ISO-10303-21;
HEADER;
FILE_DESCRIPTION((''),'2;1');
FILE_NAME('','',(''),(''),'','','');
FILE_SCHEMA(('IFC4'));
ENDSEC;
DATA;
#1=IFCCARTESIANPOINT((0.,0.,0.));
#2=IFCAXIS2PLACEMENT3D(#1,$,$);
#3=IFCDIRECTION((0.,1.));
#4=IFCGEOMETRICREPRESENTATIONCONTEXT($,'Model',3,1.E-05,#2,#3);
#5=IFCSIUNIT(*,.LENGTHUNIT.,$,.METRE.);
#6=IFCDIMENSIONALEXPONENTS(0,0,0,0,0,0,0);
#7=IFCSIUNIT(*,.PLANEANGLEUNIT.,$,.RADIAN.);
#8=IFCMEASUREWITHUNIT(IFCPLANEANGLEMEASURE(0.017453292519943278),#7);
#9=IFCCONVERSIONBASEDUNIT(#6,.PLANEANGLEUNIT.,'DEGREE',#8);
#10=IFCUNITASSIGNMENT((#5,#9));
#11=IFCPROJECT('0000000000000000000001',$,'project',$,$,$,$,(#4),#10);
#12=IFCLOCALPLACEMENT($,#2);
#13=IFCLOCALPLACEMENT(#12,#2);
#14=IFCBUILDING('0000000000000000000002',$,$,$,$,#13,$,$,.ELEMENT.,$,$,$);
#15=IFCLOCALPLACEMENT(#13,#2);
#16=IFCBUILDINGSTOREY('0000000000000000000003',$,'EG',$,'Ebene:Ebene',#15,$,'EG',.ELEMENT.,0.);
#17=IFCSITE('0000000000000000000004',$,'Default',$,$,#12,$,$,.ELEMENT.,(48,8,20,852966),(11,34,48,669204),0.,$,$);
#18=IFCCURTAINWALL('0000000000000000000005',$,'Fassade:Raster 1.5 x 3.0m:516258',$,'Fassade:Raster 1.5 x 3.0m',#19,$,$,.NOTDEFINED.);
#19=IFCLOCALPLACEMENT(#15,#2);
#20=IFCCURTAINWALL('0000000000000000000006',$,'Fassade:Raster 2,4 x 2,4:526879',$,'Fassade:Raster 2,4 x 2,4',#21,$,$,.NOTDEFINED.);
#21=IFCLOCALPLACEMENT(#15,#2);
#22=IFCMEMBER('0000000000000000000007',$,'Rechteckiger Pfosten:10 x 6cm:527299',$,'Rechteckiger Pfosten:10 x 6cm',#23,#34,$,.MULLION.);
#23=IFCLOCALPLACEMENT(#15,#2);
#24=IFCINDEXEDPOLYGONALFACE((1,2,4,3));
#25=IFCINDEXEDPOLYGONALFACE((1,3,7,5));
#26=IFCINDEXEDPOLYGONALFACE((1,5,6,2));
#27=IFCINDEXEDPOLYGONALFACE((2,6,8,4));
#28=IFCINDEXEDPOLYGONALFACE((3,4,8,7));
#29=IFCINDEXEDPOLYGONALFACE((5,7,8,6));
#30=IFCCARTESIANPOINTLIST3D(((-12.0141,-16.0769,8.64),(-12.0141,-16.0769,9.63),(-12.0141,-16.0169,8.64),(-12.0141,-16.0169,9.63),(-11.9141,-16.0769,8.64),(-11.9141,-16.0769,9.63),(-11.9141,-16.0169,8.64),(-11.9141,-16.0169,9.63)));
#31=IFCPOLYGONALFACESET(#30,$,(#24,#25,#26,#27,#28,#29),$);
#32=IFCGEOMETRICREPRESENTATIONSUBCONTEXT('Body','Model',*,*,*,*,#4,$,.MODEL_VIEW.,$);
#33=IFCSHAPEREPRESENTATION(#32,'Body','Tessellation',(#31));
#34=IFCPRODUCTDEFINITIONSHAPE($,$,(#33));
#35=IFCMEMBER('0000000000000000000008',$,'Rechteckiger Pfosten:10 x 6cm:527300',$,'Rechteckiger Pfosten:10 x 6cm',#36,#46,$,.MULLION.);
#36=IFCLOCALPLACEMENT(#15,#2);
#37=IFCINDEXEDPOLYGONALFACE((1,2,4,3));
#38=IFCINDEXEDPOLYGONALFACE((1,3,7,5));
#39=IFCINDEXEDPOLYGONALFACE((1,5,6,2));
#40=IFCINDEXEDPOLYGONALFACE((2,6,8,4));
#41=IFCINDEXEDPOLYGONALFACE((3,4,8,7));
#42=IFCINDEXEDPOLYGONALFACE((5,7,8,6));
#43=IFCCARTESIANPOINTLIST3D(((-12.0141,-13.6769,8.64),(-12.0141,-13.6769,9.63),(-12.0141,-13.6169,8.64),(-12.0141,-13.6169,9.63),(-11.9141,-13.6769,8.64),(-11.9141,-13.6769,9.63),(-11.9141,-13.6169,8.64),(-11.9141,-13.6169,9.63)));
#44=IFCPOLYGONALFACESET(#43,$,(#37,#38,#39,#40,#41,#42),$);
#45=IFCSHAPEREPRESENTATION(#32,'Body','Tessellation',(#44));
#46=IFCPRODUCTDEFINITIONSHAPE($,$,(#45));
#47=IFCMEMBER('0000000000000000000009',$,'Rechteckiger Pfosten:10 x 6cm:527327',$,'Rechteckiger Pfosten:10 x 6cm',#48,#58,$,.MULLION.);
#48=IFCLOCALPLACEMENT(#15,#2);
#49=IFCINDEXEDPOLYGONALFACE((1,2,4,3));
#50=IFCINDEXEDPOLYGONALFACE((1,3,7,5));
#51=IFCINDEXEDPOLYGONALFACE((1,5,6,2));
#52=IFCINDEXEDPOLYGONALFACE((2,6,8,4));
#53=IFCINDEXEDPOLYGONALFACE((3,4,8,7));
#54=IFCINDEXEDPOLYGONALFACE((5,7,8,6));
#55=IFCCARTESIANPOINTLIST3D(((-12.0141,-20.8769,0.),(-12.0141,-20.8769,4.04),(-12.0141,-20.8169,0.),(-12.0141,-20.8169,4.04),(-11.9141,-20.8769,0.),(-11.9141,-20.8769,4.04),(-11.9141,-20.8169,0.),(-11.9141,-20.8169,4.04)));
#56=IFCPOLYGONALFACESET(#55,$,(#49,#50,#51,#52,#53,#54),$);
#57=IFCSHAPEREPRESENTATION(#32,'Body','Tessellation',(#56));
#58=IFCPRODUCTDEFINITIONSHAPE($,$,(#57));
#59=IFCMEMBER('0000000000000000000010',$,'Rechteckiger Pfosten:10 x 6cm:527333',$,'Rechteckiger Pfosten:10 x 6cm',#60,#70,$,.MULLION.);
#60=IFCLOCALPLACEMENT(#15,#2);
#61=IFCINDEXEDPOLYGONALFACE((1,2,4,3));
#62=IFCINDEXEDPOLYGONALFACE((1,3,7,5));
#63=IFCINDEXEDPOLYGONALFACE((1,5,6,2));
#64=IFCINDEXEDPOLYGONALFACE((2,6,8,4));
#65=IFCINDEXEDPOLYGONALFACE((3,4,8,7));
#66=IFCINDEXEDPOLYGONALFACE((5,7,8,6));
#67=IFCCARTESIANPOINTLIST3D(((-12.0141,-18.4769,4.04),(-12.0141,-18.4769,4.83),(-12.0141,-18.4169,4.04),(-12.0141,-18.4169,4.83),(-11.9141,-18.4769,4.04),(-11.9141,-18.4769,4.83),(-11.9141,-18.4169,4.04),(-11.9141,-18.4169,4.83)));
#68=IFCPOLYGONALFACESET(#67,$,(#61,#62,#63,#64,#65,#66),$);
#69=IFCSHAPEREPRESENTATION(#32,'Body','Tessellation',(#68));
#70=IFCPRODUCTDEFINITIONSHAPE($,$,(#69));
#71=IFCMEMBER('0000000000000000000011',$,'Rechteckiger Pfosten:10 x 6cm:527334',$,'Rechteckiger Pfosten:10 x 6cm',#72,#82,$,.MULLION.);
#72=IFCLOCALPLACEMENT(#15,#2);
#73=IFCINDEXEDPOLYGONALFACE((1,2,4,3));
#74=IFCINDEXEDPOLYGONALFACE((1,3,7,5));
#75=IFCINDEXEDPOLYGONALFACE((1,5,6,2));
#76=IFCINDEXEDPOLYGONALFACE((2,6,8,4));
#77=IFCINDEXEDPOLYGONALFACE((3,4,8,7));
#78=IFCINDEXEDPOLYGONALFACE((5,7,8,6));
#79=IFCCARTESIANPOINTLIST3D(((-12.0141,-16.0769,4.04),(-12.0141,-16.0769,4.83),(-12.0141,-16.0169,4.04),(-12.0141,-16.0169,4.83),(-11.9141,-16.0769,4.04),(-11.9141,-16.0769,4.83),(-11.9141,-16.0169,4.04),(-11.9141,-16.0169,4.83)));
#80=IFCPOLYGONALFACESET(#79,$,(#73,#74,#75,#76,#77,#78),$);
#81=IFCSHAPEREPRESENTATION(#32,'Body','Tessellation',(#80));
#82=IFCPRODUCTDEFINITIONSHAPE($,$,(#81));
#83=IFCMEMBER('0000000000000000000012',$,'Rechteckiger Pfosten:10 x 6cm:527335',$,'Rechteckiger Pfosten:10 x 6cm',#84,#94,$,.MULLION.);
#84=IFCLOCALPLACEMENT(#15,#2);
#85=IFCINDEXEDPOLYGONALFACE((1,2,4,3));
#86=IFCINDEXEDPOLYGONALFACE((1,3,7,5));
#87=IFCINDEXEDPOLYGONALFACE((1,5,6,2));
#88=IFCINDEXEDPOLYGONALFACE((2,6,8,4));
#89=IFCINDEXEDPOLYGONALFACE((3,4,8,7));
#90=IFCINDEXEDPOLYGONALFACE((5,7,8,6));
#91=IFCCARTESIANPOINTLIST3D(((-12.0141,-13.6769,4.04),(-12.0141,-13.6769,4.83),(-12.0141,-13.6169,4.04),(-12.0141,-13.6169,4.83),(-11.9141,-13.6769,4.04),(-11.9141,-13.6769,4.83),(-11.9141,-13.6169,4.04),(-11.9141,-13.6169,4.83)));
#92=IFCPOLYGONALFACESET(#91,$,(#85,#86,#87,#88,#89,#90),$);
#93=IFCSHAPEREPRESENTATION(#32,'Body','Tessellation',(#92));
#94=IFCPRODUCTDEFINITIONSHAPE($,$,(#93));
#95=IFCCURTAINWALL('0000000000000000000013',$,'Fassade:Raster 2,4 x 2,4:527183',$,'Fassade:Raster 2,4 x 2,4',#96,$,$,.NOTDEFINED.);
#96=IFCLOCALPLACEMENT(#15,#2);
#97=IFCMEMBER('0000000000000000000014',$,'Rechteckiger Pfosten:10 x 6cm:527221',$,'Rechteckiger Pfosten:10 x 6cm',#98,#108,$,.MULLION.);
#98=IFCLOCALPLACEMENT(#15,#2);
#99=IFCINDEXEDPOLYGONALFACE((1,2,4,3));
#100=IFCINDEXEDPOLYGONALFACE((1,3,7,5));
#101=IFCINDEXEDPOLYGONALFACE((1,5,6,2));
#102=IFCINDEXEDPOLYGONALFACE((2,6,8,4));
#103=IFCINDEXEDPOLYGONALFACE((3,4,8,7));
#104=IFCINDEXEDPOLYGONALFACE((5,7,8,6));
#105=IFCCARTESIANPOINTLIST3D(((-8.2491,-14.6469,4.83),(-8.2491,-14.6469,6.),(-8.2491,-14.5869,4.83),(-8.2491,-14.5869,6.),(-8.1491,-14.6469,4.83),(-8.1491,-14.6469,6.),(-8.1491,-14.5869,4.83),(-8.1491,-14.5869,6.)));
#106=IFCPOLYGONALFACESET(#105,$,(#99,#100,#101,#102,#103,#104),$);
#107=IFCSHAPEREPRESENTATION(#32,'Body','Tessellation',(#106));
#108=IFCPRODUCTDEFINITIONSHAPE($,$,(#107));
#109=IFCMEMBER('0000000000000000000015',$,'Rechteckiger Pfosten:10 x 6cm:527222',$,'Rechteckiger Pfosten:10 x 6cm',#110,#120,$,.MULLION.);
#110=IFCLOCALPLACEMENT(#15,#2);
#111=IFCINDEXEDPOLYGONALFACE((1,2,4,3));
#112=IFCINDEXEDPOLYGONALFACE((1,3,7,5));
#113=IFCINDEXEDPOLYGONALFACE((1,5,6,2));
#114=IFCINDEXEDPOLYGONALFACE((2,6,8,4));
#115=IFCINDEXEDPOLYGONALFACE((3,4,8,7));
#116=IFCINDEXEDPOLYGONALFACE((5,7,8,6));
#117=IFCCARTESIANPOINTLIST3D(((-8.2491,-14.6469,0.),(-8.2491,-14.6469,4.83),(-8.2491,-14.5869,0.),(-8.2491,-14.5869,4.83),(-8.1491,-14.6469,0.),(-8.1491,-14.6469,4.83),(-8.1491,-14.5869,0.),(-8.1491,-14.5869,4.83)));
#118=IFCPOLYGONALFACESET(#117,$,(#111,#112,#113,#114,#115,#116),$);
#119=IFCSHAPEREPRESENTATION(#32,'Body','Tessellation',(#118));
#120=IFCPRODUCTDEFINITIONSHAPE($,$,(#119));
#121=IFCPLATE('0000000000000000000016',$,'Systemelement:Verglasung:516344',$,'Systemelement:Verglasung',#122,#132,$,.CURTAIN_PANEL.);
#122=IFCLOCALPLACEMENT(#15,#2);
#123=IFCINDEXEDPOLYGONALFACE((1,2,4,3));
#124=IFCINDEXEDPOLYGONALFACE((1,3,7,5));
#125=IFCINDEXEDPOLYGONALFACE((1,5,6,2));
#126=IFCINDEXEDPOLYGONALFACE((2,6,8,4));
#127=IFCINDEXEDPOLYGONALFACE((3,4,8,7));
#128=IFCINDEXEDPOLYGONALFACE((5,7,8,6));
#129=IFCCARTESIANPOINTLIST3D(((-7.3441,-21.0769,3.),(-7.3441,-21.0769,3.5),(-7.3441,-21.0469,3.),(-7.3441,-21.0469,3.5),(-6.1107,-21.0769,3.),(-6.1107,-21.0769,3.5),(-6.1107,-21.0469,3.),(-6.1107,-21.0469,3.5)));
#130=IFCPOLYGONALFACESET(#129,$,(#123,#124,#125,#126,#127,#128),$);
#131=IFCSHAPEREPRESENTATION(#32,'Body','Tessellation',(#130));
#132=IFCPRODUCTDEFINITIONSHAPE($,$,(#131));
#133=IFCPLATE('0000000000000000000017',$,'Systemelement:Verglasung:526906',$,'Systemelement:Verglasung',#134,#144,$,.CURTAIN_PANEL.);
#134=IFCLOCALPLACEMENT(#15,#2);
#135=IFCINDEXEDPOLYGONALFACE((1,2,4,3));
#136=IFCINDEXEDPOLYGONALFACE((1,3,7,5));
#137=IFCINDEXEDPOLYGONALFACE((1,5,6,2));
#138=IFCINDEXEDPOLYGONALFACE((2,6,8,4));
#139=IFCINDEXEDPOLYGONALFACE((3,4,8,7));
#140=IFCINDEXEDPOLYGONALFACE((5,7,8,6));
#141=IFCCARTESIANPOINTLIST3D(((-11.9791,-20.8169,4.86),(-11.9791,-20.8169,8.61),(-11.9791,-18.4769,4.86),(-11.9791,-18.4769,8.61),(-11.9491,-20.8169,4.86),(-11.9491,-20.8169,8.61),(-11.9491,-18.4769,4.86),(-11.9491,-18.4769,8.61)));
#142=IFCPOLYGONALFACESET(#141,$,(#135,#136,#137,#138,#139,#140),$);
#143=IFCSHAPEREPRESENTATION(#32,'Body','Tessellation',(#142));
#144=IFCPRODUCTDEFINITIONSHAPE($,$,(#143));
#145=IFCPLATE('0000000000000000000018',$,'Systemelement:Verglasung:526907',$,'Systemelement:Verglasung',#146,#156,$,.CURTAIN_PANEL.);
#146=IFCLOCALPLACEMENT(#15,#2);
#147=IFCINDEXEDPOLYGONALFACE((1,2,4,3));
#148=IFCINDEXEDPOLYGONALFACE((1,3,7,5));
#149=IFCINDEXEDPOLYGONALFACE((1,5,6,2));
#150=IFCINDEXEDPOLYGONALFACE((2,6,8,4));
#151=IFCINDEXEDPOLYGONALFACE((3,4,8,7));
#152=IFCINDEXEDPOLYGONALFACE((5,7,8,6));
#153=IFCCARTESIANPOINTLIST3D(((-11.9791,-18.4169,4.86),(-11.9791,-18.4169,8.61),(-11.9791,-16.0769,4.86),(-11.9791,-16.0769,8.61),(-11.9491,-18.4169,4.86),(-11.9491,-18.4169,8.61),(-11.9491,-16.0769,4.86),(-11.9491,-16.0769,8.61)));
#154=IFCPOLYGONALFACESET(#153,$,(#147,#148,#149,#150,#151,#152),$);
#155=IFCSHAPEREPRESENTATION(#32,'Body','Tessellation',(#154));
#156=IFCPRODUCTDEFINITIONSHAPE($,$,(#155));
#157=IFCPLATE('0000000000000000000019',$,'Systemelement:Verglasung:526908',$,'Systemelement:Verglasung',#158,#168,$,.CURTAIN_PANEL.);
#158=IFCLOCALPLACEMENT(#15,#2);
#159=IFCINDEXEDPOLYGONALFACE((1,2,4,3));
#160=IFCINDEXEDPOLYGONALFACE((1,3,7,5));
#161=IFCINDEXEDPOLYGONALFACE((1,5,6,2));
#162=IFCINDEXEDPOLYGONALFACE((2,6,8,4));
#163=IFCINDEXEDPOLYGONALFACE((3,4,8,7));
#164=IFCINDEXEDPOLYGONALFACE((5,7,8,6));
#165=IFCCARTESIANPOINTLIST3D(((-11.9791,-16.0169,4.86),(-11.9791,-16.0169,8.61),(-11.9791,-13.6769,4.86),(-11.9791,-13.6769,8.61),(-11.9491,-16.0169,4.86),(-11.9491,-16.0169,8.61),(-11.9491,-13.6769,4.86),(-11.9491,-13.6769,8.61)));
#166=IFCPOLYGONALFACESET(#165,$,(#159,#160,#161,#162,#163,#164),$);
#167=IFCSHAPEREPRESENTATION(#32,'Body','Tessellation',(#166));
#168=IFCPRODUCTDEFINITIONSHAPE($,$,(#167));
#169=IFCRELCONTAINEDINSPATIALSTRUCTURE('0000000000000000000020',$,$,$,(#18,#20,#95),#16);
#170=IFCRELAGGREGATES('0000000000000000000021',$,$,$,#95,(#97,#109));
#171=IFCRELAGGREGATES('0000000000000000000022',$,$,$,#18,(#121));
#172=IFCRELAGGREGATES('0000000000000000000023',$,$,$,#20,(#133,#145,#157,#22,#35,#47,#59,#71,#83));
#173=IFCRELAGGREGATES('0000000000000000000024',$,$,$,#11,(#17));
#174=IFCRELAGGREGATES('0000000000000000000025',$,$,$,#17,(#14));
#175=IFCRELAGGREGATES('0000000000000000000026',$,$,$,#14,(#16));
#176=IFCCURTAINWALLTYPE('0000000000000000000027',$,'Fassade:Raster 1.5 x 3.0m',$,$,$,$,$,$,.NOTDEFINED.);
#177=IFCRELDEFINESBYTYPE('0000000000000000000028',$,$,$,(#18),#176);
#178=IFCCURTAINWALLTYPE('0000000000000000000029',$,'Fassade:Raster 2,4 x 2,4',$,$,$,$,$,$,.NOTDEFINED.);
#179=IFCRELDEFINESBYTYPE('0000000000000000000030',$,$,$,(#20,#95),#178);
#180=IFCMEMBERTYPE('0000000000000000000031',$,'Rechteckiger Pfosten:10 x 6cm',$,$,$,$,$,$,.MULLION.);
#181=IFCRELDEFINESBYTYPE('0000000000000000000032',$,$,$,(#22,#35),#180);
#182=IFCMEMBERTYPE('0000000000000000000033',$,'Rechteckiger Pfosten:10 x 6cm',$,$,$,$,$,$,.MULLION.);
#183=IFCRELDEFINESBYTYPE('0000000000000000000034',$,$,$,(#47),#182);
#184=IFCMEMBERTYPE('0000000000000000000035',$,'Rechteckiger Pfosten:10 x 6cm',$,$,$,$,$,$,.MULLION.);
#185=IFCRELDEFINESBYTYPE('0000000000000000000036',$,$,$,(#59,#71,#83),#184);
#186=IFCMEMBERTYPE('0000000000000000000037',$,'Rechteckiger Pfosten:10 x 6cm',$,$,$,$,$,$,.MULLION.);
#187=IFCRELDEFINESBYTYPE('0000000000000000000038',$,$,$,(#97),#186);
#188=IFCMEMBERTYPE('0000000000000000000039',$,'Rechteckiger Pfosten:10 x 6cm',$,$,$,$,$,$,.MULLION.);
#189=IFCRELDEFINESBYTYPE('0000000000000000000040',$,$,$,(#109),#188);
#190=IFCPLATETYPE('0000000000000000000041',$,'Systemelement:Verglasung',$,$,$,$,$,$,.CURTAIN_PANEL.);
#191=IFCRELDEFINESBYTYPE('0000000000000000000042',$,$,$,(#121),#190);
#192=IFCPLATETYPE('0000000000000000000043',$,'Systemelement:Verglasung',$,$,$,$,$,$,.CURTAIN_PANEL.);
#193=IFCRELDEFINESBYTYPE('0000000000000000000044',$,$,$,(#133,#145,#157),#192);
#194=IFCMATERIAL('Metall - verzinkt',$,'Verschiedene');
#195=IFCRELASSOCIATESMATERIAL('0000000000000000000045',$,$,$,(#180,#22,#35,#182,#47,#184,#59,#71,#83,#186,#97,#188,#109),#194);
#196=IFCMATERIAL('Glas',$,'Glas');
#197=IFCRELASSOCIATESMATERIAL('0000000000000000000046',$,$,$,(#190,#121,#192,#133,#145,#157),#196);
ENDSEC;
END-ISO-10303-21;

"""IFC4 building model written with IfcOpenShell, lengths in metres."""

from ifc_helpers import new_model, entity, si_unit, converted_unit, direction, frame, origin, place, context, subcontext, project, spatial, indexed_curve, outline, extrude, source, transform, mapped, material, type_object, type_shapes, element, aggregate, save


model = new_model("IFC4")

# Units and contexts
model_context = context("Model", 3, precision=1e-05, world=origin(), true_north=direction((0.0, 1.0)))
body_context = subcontext(model_context, "Body", "Model", "MODEL_VIEW")
ifc_project = project(units=[si_unit("LENGTHUNIT", "METRE"), converted_unit("PLANEANGLEUNIT", "DEGREE", entity("IfcPlaneAngleMeasure", 0.017453292519943278), si_unit("PLANEANGLEUNIT", "RADIAN"), dimensions=[0, 0, 0, 0, 0, 0, 0])], contexts=[model_context])

# Site, building, storey
site_placement = place(None, origin())
site = spatial("IfcSite", under=ifc_project, at=site_placement, Name="Default", CompositionType="ELEMENT", RefLatitude=(48, 8, 20, 852966), RefLongitude=(11, 34, 48, 669204), RefElevation=0.0)
building_placement = place(site_placement, origin())
building = spatial("IfcBuilding", under=site, at=building_placement, CompositionType="ELEMENT")
storey_placement = place(building_placement, origin())
storey = spatial("IfcBuildingStorey", under=building, at=storey_placement, Name="EG", ObjectType="Ebene:Ebene", LongName="EG", CompositionType="ELEMENT", Elevation=0.0)

# Curtain wall
curtain_wall_type_1 = type_object("IfcCurtainWallType", Name="Fassade:Raster 1.5 x 3.0m", PredefinedType="NOTDEFINED")
curtain_wall_1_placement = place(storey_placement, origin())
curtain_wall_1 = element("IfcCurtainWall", 1, at=curtain_wall_1_placement, inside=storey, type_object=curtain_wall_type_1, Name="Fassade:Raster 1.5 x 3.0m:516258", ObjectType="Fassade:Raster 1.5 x 3.0m", PredefinedType="NOTDEFINED")
ifc_material_1 = material(Name="Metall - verzinkt", Category="Verschiedene")

# Curtain walls, members
curtain_wall_type_2 = type_object("IfcCurtainWallType", Name="Fassade:Raster 2,4 x 2,4", PredefinedType="NOTDEFINED")
curtain_wall_2_placement = place(storey_placement, origin())
curtain_wall_2 = element("IfcCurtainWall", 2, at=curtain_wall_2_placement, inside=storey, type_object=curtain_wall_type_2, Name="Fassade:Raster 2,4 x 2,4:526879", ObjectType="Fassade:Raster 2,4 x 2,4", PredefinedType="NOTDEFINED")
member_type_1 = type_object("IfcMemberType", Name="Rechteckiger Pfosten:10 x 6cm", PredefinedType="MULLION", material=ifc_material_1)
shared_shape_1 = source(origin(), body_context, "Body", "SweptSolid", [
    extrude(outline(indexed_curve([(-0.03, -0.05), (0.03, -0.05), (0.03, 0.05), (-0.03, 0.05), (-0.03, -0.05)], self_intersect=False)), frame((0.0, 0.0, -0.99), z_axis=(0.0, 0.0, 1.0), x_axis=(-1.0, 0.0, 0.0)), (0.0, 0.0, 1.0), 0.99),
])
type_shapes(member_type_1, [shared_shape_1])
member_1_placement = place(curtain_wall_2_placement, frame((-11.9641, -16.0469, 8.64), z_axis=(0.0, 0.0, -1.0), x_axis=(0.0, 1.0, 0.0)))
member_1 = element("IfcMember", 3, at=member_1_placement, type_object=member_type_1, material=ifc_material_1, Name="Rechteckiger Pfosten:10 x 6cm:527299", ObjectType="Rechteckiger Pfosten:10 x 6cm", PredefinedType="MULLION", context=body_context, shape_type="MappedRepresentation", body=[
    mapped(shared_shape_1, transform((0.0, 0.0, 0.0), scale=1.0)),
])
member_2_placement = place(curtain_wall_2_placement, frame((-11.9641, -13.6469, 8.64), z_axis=(0.0, 0.0, -1.0), x_axis=(0.0, 1.0, 0.0)))
member_2 = element("IfcMember", 4, at=member_2_placement, type_object=member_type_1, material=ifc_material_1, Name="Rechteckiger Pfosten:10 x 6cm:527300", ObjectType="Rechteckiger Pfosten:10 x 6cm", PredefinedType="MULLION", context=body_context, shape_type="MappedRepresentation", body=[
    mapped(shared_shape_1, transform((0.0, 0.0, 0.0), scale=1.0)),
])
member_type_2 = type_object("IfcMemberType", Name="Rechteckiger Pfosten:10 x 6cm", PredefinedType="MULLION", material=ifc_material_1)
shared_shape_2 = source(origin(), body_context, "Body", "SweptSolid", [
    extrude(outline(indexed_curve([(-0.03, -0.05), (0.03, -0.05), (0.03, 0.05), (-0.03, 0.05), (-0.03, -0.05)], self_intersect=False)), frame((-0.03, 0.0, -4.04), z_axis=(0.0, 0.0, 1.0), x_axis=(-1.0, 0.0, 0.0)), (0.0, 0.0, 1.0), 4.04),
])
type_shapes(member_type_2, [shared_shape_2])
member_3_placement = place(curtain_wall_2_placement, frame((-11.9641, -20.8769, 4.04), z_axis=(0.0, 0.0, 1.0), x_axis=(0.0, -1.0, 0.0)))
member_3 = element("IfcMember", 5, at=member_3_placement, type_object=member_type_2, material=ifc_material_1, Name="Rechteckiger Pfosten:10 x 6cm:527327", ObjectType="Rechteckiger Pfosten:10 x 6cm", PredefinedType="MULLION", context=body_context, shape_type="MappedRepresentation", body=[
    mapped(shared_shape_2, transform((0.0, 0.0, 0.0), scale=1.0)),
])
member_type_3 = type_object("IfcMemberType", Name="Rechteckiger Pfosten:10 x 6cm", PredefinedType="MULLION", material=ifc_material_1)
shared_shape_3 = source(origin(), body_context, "Body", "SweptSolid", [
    extrude(outline(indexed_curve([(-0.03, -0.05), (0.03, -0.05), (0.03, 0.05), (-0.03, 0.05), (-0.03, -0.05)], self_intersect=False)), frame((0.0, 0.0, -0.79), z_axis=(0.0, 0.0, 1.0), x_axis=(-1.0, 0.0, 0.0)), (0.0, 0.0, 1.0), 0.79),
])
type_shapes(member_type_3, [shared_shape_3])
member_4_placement = place(curtain_wall_2_placement, frame((-11.9641, -18.4469, 4.04), z_axis=(0.0, 0.0, -1.0), x_axis=(0.0, 1.0, 0.0)))
member_4 = element("IfcMember", 6, at=member_4_placement, type_object=member_type_3, material=ifc_material_1, Name="Rechteckiger Pfosten:10 x 6cm:527333", ObjectType="Rechteckiger Pfosten:10 x 6cm", PredefinedType="MULLION", context=body_context, shape_type="MappedRepresentation", body=[
    mapped(shared_shape_3, transform((0.0, 0.0, 0.0), scale=1.0)),
])
member_5_placement = place(curtain_wall_2_placement, frame((-11.9641, -16.0469, 4.04), z_axis=(0.0, 0.0, -1.0), x_axis=(0.0, 1.0, 0.0)))
member_5 = element("IfcMember", 7, at=member_5_placement, type_object=member_type_3, material=ifc_material_1, Name="Rechteckiger Pfosten:10 x 6cm:527334", ObjectType="Rechteckiger Pfosten:10 x 6cm", PredefinedType="MULLION", context=body_context, shape_type="MappedRepresentation", body=[
    mapped(shared_shape_3, transform((0.0, 0.0, 0.0), scale=1.0)),
])
member_6_placement = place(curtain_wall_2_placement, frame((-11.9641, -13.6469, 4.04), z_axis=(0.0, 0.0, -1.0), x_axis=(0.0, 1.0, 0.0)))
member_6 = element("IfcMember", 8, at=member_6_placement, type_object=member_type_3, material=ifc_material_1, Name="Rechteckiger Pfosten:10 x 6cm:527335", ObjectType="Rechteckiger Pfosten:10 x 6cm", PredefinedType="MULLION", context=body_context, shape_type="MappedRepresentation", body=[
    mapped(shared_shape_3, transform((0.0, 0.0, 0.0), scale=1.0)),
])
curtain_wall_3_placement = place(storey_placement, origin())
curtain_wall_3 = element("IfcCurtainWall", 9, at=curtain_wall_3_placement, inside=storey, type_object=curtain_wall_type_2, Name="Fassade:Raster 2,4 x 2,4:527183", ObjectType="Fassade:Raster 2,4 x 2,4", PredefinedType="NOTDEFINED")
member_type_4 = type_object("IfcMemberType", Name="Rechteckiger Pfosten:10 x 6cm", PredefinedType="MULLION", material=ifc_material_1)
shared_shape_4 = source(origin(), body_context, "Body", "SweptSolid", [
    extrude(outline(indexed_curve([(-0.03, -0.05), (0.03, -0.05), (0.03, 0.05), (-0.03, 0.05), (-0.03, -0.05)], self_intersect=False)), frame((-0.03, 0.0, -1.17), z_axis=(0.0, 0.0, 1.0), x_axis=(-1.0, 0.0, 0.0)), (0.0, 0.0, 1.0), 1.17),
])
type_shapes(member_type_4, [shared_shape_4])
member_7_placement = place(curtain_wall_3_placement, frame((-8.1991, -14.6469, 6.0), z_axis=(0.0, 0.0, 1.0), x_axis=(0.0, -1.0, 0.0)))
member_7 = element("IfcMember", 10, at=member_7_placement, type_object=member_type_4, material=ifc_material_1, Name="Rechteckiger Pfosten:10 x 6cm:527221", ObjectType="Rechteckiger Pfosten:10 x 6cm", PredefinedType="MULLION", context=body_context, shape_type="MappedRepresentation", body=[
    mapped(shared_shape_4, transform((0.0, 0.0, 0.0), scale=1.0)),
])
member_type_5 = type_object("IfcMemberType", Name="Rechteckiger Pfosten:10 x 6cm", PredefinedType="MULLION", material=ifc_material_1)
shared_shape_5 = source(origin(), body_context, "Body", "SweptSolid", [
    extrude(outline(indexed_curve([(-0.03, -0.05), (0.03, -0.05), (0.03, 0.05), (-0.03, 0.05), (-0.03, -0.05)], self_intersect=False)), frame((-0.03, 0.0, -4.83), z_axis=(0.0, 0.0, 1.0), x_axis=(-1.0, 0.0, 0.0)), (0.0, 0.0, 1.0), 4.83),
])
type_shapes(member_type_5, [shared_shape_5])
member_8_placement = place(curtain_wall_3_placement, frame((-8.1991, -14.6469, 4.83), z_axis=(0.0, 0.0, 1.0), x_axis=(0.0, -1.0, 0.0)))
member_8 = element("IfcMember", 11, at=member_8_placement, type_object=member_type_5, material=ifc_material_1, Name="Rechteckiger Pfosten:10 x 6cm:527222", ObjectType="Rechteckiger Pfosten:10 x 6cm", PredefinedType="MULLION", context=body_context, shape_type="MappedRepresentation", body=[
    mapped(shared_shape_5, transform((0.0, 0.0, 0.0), scale=1.0)),
])
aggregate(curtain_wall_3, [member_7, member_8])

# Plates
ifc_material_2 = material(Name="Glas", Category="Glas")
plate_type_1 = type_object("IfcPlateType", Name="Systemelement:Verglasung", PredefinedType="CURTAIN_PANEL", material=ifc_material_2)
shared_shape_6 = source(origin(), body_context, "Body", "SweptSolid", [
    extrude(outline(indexed_curve([(-0.015, -0.6167), (0.015, -0.6167), (0.015, 0.6167), (-0.015, 0.6167), (-0.015, -0.6167)], self_intersect=False)), frame((0.0, 0.0, 0.0), z_axis=(0.0, 0.0, 1.0), x_axis=(0.0, 1.0, 0.0)), (0.0, 0.0, 1.0), 0.5),
])
type_shapes(plate_type_1, [shared_shape_6])
plate_1_placement = place(curtain_wall_1_placement, frame((-6.7274, -21.0619, 3.0)))
plate_1 = element("IfcPlate", 12, at=plate_1_placement, type_object=plate_type_1, material=ifc_material_2, Name="Systemelement:Verglasung:516344", ObjectType="Systemelement:Verglasung", PredefinedType="CURTAIN_PANEL", context=body_context, shape_type="MappedRepresentation", body=[
    mapped(shared_shape_6, transform((0.0, 0.0, 0.0), scale=1.0)),
])
aggregate(curtain_wall_1, [plate_1])
plate_type_2 = type_object("IfcPlateType", Name="Systemelement:Verglasung", PredefinedType="CURTAIN_PANEL", material=ifc_material_2)
shared_shape_7 = source(origin(), body_context, "Body", "SweptSolid", [
    extrude(outline(indexed_curve([(-0.015, -1.17), (0.015, -1.17), (0.015, 1.17), (-0.015, 1.17), (-0.015, -1.17)], self_intersect=False)), frame((0.0, 0.0, 0.0), z_axis=(0.0, 0.0, 1.0), x_axis=(0.0, 1.0, 0.0)), (0.0, 0.0, 1.0), 3.75),
])
type_shapes(plate_type_2, [shared_shape_7])
plate_2_placement = place(curtain_wall_2_placement, frame((-11.9641, -19.6469, 4.86), z_axis=(0.0, 0.0, 1.0), x_axis=(0.0, 1.0, 0.0)))
plate_2 = element("IfcPlate", 13, at=plate_2_placement, type_object=plate_type_2, material=ifc_material_2, Name="Systemelement:Verglasung:526906", ObjectType="Systemelement:Verglasung", PredefinedType="CURTAIN_PANEL", context=body_context, shape_type="MappedRepresentation", body=[
    mapped(shared_shape_7, transform((0.0, 0.0, 0.0), scale=1.0)),
])
plate_3_placement = place(curtain_wall_2_placement, frame((-11.9641, -17.2469, 4.86), z_axis=(0.0, 0.0, 1.0), x_axis=(0.0, 1.0, 0.0)))
plate_3 = element("IfcPlate", 14, at=plate_3_placement, type_object=plate_type_2, material=ifc_material_2, Name="Systemelement:Verglasung:526907", ObjectType="Systemelement:Verglasung", PredefinedType="CURTAIN_PANEL", context=body_context, shape_type="MappedRepresentation", body=[
    mapped(shared_shape_7, transform((0.0, 0.0, 0.0), scale=1.0)),
])
plate_4_placement = place(curtain_wall_2_placement, frame((-11.9641, -14.8469, 4.86), z_axis=(0.0, 0.0, 1.0), x_axis=(0.0, 1.0, 0.0)))
plate_4 = element("IfcPlate", 15, at=plate_4_placement, type_object=plate_type_2, material=ifc_material_2, Name="Systemelement:Verglasung:526908", ObjectType="Systemelement:Verglasung", PredefinedType="CURTAIN_PANEL", context=body_context, shape_type="MappedRepresentation", body=[
    mapped(shared_shape_7, transform((0.0, 0.0, 0.0), scale=1.0)),
])
aggregate(curtain_wall_2, [plate_2, plate_3, plate_4, member_1, member_2, member_3, member_4, member_5, member_6])

save(model, "model.ifc")
